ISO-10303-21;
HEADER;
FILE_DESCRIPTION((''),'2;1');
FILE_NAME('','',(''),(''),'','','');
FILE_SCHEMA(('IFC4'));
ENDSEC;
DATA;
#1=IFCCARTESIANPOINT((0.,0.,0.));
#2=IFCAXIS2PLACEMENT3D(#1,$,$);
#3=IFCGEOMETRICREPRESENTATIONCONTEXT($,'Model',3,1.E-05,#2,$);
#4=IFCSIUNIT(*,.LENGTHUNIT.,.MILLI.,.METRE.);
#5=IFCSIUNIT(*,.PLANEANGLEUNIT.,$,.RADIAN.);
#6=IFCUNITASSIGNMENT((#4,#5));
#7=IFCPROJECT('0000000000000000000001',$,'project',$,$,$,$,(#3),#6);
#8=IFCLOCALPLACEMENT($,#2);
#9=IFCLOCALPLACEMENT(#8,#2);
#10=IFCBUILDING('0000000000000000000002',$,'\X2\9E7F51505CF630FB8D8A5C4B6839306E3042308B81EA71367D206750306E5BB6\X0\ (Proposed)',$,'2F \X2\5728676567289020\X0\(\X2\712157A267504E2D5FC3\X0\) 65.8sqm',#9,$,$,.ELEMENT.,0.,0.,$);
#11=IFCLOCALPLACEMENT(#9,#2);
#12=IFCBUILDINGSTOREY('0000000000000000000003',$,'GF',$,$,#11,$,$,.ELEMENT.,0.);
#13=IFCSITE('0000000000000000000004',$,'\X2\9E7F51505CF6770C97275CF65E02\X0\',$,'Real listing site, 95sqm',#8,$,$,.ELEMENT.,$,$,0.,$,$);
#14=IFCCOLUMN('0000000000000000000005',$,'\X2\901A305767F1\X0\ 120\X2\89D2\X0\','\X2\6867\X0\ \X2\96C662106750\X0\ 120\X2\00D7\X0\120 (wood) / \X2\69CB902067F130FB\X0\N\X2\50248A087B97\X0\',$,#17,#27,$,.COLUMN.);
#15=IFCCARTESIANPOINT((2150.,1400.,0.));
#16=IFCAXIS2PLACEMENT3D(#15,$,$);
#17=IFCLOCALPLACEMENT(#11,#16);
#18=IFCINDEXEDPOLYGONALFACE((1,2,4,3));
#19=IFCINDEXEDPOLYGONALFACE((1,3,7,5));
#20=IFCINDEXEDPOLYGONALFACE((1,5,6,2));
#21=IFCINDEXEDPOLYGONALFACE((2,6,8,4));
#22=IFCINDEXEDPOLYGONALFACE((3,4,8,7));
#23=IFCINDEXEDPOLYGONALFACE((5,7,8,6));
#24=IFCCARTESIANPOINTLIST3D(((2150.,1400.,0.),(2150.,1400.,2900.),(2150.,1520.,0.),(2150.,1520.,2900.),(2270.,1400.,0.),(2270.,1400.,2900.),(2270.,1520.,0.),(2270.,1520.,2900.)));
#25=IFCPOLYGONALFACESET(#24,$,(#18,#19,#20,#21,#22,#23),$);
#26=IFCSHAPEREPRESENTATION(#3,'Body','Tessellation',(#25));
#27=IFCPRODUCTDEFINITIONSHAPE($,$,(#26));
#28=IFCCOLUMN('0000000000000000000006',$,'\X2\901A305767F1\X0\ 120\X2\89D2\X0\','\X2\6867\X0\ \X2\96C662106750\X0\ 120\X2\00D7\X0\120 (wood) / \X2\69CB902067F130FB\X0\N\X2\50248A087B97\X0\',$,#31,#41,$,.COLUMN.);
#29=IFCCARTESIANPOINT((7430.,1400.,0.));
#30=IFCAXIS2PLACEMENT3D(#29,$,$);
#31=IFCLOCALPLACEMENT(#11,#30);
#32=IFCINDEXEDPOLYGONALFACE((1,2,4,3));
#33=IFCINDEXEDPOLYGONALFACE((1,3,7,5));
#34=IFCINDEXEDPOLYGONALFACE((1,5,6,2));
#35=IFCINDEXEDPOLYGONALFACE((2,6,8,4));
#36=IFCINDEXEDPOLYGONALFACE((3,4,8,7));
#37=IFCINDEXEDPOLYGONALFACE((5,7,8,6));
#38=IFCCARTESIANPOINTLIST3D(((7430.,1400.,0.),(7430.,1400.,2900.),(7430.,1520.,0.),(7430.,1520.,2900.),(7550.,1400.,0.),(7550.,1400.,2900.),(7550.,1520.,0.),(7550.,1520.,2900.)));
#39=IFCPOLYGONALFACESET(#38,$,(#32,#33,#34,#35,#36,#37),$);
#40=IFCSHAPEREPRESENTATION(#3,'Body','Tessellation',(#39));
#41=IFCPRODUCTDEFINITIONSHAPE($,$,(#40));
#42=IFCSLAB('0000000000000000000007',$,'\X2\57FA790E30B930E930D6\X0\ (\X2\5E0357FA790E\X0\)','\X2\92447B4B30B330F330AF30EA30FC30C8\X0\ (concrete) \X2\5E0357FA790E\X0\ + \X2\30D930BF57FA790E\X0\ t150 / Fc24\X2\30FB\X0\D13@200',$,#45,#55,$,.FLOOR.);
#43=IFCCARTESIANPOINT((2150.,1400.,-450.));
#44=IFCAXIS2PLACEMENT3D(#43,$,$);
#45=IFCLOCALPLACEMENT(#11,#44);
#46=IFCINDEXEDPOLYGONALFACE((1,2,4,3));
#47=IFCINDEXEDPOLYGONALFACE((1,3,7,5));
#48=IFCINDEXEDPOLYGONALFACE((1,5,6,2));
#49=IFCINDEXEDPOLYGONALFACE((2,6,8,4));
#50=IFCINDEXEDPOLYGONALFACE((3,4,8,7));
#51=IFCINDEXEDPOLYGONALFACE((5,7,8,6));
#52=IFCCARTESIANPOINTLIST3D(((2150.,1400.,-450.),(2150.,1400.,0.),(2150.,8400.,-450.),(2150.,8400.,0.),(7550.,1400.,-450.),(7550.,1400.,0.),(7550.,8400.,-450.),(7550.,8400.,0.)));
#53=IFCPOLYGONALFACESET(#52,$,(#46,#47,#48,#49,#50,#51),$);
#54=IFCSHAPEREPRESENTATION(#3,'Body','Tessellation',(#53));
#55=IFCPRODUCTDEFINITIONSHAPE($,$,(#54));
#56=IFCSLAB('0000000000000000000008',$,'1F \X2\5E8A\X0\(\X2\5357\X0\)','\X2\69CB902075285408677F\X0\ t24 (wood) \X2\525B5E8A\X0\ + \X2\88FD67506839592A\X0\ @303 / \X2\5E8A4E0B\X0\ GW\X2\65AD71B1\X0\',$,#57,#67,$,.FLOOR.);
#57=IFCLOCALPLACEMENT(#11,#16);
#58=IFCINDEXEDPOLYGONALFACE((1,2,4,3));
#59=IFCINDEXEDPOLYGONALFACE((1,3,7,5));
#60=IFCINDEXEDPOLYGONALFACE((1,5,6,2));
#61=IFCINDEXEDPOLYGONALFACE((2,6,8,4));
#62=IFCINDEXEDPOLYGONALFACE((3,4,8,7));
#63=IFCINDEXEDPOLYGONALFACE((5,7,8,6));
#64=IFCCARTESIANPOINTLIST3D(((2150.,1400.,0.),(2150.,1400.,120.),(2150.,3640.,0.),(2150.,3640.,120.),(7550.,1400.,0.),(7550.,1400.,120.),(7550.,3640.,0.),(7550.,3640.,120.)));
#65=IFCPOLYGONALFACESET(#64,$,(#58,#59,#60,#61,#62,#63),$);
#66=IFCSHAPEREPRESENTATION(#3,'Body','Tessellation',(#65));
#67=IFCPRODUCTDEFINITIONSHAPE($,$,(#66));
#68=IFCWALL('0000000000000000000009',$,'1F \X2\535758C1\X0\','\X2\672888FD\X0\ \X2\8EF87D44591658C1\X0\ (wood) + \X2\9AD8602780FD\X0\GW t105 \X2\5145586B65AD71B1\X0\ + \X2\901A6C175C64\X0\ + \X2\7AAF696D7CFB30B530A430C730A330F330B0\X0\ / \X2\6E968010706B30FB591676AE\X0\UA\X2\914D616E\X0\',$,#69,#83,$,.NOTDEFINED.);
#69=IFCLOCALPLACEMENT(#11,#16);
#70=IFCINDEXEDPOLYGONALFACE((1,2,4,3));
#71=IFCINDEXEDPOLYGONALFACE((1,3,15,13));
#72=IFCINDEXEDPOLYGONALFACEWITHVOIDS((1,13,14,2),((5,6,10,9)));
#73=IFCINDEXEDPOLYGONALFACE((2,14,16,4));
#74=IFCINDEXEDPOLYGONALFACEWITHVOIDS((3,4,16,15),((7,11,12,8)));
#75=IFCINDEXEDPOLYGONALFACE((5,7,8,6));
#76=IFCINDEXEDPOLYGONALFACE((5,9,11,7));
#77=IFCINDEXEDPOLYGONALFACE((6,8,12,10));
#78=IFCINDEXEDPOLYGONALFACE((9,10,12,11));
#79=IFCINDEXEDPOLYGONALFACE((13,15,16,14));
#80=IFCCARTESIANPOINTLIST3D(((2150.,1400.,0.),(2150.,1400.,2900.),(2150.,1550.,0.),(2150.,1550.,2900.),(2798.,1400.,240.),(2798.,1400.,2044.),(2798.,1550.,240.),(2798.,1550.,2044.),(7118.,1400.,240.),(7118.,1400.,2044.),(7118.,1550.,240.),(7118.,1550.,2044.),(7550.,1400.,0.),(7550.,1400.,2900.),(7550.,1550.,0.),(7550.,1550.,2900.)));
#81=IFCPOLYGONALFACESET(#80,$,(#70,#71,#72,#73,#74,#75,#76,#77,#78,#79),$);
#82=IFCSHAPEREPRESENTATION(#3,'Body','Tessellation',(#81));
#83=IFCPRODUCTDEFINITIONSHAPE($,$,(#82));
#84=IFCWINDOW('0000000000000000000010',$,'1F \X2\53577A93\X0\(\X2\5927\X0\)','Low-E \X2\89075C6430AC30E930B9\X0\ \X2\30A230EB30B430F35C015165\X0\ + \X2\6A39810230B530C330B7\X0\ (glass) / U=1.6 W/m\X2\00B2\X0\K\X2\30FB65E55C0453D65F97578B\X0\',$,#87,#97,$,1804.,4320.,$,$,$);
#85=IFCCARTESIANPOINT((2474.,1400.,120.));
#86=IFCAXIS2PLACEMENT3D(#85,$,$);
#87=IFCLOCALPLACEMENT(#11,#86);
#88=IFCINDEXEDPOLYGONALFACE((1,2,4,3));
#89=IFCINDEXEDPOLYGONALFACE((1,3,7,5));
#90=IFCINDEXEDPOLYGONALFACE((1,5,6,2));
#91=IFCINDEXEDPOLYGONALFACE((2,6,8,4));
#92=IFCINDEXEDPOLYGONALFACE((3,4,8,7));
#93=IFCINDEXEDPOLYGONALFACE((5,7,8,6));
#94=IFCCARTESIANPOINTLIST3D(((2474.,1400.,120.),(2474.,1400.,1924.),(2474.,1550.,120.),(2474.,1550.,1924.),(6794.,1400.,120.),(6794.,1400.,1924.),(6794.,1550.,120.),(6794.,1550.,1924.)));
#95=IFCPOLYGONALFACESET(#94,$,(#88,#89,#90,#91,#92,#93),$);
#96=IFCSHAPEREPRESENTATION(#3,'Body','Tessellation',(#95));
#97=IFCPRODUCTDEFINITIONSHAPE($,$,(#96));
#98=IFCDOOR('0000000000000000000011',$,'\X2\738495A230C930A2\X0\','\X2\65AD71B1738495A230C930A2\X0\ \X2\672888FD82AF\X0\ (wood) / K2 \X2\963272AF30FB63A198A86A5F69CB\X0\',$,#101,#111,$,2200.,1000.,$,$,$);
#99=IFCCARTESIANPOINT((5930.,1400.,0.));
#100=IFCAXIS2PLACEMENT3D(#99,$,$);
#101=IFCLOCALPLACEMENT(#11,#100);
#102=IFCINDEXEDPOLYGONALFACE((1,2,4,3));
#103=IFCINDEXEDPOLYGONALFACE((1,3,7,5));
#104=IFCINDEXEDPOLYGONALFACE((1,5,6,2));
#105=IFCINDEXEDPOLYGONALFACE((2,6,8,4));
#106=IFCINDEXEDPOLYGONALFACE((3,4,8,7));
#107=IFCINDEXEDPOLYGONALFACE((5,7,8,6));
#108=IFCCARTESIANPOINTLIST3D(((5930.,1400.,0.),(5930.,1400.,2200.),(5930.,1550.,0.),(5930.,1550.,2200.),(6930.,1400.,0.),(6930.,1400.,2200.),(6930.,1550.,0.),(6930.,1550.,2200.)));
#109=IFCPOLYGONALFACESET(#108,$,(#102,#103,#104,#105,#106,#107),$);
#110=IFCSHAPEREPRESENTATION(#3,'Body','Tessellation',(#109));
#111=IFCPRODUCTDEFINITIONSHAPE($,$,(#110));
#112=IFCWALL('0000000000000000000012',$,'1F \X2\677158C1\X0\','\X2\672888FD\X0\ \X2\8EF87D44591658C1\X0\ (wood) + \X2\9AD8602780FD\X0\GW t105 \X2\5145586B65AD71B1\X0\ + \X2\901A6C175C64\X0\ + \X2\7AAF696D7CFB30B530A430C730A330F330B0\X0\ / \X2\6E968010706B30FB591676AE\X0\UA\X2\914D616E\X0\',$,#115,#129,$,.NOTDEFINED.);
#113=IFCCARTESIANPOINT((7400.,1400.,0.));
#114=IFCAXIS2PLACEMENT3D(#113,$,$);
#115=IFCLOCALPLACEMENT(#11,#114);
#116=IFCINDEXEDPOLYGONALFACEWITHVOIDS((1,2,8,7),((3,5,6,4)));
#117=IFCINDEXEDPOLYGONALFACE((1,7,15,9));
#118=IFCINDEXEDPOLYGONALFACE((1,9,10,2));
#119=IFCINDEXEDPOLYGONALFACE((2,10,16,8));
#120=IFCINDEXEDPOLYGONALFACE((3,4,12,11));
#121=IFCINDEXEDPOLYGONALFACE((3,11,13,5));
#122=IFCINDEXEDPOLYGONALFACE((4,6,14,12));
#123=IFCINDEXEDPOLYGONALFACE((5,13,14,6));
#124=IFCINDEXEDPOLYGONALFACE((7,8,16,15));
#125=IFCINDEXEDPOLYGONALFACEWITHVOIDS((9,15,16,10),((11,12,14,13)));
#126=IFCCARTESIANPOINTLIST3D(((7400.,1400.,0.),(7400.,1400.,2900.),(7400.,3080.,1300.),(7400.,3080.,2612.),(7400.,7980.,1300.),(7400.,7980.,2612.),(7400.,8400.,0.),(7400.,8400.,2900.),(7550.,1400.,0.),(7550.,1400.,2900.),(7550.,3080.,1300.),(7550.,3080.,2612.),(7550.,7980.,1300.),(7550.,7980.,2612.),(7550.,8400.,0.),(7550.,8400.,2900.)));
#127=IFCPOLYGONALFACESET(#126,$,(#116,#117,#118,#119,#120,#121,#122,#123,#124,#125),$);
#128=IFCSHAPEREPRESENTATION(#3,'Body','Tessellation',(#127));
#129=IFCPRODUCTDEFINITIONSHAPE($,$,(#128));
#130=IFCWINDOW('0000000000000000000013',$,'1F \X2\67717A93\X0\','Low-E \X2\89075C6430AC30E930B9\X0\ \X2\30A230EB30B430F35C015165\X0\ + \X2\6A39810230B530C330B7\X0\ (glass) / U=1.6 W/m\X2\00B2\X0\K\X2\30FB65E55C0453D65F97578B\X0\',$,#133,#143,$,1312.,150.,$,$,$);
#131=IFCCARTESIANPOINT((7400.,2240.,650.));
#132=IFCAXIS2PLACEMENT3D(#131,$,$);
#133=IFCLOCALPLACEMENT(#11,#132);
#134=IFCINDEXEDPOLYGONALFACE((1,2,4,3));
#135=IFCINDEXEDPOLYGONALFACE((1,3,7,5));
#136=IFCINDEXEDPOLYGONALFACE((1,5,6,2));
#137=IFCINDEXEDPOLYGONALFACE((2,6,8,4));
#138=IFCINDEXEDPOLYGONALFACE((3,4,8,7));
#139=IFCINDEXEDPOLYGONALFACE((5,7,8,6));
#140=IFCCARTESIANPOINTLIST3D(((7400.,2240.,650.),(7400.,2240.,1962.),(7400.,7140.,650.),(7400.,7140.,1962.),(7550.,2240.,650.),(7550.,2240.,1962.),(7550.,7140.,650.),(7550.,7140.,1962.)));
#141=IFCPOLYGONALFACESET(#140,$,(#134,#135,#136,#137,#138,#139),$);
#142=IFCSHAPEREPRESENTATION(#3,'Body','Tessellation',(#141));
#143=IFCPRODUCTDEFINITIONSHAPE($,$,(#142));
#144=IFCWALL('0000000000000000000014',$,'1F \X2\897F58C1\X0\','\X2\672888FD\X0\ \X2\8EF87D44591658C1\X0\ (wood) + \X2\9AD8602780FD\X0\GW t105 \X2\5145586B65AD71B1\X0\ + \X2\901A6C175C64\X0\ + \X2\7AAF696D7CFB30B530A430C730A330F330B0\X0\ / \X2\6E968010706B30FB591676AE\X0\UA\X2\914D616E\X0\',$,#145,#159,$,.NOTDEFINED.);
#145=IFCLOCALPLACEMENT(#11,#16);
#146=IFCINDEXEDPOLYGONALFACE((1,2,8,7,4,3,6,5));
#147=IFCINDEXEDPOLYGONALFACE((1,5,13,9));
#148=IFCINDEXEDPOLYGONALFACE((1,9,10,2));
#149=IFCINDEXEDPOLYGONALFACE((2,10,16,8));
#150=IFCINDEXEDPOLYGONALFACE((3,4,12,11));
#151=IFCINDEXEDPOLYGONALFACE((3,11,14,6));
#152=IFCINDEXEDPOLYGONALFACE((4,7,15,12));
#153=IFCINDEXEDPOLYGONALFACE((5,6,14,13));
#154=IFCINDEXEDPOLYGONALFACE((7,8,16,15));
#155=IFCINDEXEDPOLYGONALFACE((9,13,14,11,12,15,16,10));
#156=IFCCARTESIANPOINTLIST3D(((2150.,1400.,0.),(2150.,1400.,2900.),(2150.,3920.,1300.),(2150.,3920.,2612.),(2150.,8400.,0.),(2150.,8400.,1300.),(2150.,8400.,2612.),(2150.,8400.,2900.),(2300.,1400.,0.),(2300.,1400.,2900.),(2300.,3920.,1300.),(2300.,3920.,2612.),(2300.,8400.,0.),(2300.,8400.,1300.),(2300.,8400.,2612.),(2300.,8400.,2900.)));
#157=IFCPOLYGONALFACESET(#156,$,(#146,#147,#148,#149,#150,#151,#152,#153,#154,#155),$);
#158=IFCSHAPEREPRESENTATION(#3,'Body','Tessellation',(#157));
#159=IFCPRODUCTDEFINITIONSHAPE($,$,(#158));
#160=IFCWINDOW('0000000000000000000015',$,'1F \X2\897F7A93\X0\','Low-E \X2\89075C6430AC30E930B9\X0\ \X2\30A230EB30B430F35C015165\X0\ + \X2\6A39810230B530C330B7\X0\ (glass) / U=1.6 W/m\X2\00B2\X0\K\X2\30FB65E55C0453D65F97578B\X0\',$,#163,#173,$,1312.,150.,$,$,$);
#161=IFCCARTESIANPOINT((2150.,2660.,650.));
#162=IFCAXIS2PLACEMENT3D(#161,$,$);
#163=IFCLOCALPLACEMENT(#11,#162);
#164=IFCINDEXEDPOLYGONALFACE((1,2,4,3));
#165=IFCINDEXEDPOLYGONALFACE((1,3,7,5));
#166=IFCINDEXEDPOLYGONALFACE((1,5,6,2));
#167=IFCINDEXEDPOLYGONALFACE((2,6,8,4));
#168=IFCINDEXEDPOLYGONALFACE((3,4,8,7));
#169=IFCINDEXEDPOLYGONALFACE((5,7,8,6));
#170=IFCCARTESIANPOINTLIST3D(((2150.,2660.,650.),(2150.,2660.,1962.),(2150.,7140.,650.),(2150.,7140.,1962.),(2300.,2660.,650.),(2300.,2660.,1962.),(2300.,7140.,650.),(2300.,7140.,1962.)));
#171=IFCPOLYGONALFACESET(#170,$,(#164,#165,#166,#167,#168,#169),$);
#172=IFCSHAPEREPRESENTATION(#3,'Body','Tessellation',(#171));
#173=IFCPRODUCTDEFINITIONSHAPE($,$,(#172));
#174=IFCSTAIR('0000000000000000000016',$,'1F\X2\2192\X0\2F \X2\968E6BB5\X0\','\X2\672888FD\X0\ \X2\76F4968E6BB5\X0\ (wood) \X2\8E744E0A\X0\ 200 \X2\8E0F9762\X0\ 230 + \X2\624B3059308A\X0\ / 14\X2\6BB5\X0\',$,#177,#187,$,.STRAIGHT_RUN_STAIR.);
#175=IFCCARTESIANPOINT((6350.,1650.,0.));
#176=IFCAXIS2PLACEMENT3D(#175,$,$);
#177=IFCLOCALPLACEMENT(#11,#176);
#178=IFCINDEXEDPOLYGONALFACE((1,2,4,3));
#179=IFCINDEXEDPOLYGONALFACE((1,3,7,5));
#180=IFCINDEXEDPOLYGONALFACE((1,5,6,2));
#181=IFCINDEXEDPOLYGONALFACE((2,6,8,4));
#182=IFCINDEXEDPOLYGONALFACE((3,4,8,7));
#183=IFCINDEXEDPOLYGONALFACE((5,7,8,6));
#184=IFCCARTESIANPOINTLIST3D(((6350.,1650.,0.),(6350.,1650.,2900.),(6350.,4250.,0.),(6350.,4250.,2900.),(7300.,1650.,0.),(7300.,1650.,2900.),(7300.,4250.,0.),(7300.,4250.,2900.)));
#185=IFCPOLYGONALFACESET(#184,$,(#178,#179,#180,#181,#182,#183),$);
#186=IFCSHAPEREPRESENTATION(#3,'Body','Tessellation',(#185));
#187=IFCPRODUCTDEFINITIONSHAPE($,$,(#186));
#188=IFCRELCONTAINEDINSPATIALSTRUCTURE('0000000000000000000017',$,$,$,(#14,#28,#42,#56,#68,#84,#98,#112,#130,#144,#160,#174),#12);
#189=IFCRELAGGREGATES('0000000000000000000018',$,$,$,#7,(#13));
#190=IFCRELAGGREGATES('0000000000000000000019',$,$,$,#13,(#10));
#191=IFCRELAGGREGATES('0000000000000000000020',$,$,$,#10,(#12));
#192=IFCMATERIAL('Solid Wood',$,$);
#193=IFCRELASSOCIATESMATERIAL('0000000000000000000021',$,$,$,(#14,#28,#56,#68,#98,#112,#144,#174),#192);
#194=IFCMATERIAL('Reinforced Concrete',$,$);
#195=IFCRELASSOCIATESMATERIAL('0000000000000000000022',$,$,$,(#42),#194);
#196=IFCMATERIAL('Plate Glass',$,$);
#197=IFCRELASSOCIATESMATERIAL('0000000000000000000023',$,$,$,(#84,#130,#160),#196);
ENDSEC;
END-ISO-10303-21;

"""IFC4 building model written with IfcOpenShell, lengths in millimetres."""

from ifc_helpers import new_model, si_unit, frame, frame_2d, origin, place, context, project, spatial, rectangle, extrude, material, element, fill, save


model = new_model("IFC4")

# Units and contexts
model_context = context("Model", 3, precision=1e-05, world=origin())
ifc_project = project(units=[si_unit("LENGTHUNIT", "METRE", prefix="MILLI"), si_unit("PLANEANGLEUNIT", "RADIAN")], contexts=[model_context])

# Site, building, storey
site_placement = place(None, origin())
site = spatial("IfcSite", under=ifc_project, at=site_placement, Name="鹿児島県霧島市", ObjectType="Real listing site, 95sqm", CompositionType="ELEMENT", RefElevation=0.0)
building_placement = place(site_placement, origin())
building = spatial("IfcBuilding", under=site, at=building_placement, Name="鹿児島・越屋根のある自然素材の家 (Proposed)", ObjectType="2F 在来木造(無垢材中心) 65.8sqm", CompositionType="ELEMENT", ElevationOfRefHeight=0.0, ElevationOfTerrain=0.0)
storey_placement = place(building_placement, origin())
storey = spatial("IfcBuildingStorey", under=building, at=storey_placement, Name="GF", CompositionType="ELEMENT", Elevation=0.0)

# Columns
ifc_material_1 = material(Name="Solid Wood")
column_1_placement = place(storey_placement, frame((2150.0, 1400.0, 0.0)))
element("IfcColumn", 1, at=column_1_placement, inside=storey, material=ifc_material_1, Name="通し柱 120角", Description="桧 集成材 120×120 (wood) / 構造柱・N値計算", PredefinedType="COLUMN", context=model_context, shape_type="SweptSolid", body=[
    extrude(rectangle(XDim=120.0, YDim=120.0, at=frame_2d((60.0, 60.0))), frame((2150.0, 1400.0, 0.0)), (0.0, 0.0, 1.0), 2900.0),
])
column_2_placement = place(storey_placement, frame((7430.0, 1400.0, 0.0)))
element("IfcColumn", 2, at=column_2_placement, inside=storey, material=ifc_material_1, Name="通し柱 120角", Description="桧 集成材 120×120 (wood) / 構造柱・N値計算", PredefinedType="COLUMN", context=model_context, shape_type="SweptSolid", body=[
    extrude(rectangle(XDim=120.0, YDim=120.0, at=frame_2d((60.0, 60.0))), frame((7430.0, 1400.0, 0.0)), (0.0, 0.0, 1.0), 2900.0),
])

# Slabs
ifc_material_2 = material(Name="Reinforced Concrete")
slab_1_placement = place(storey_placement, frame((2150.0, 1400.0, -450.0)))
element("IfcSlab", 3, at=slab_1_placement, inside=storey, material=ifc_material_2, Name="基礎スラブ (布基礎)", Description="鉄筋コンクリート (concrete) 布基礎 + ベタ基礎 t150 / Fc24・D13@200", PredefinedType="FLOOR", context=model_context, shape_type="SweptSolid", body=[
    extrude(rectangle(XDim=5400.0, YDim=7000.0, at=frame_2d((2700.0, 3500.0))), frame((2150.0, 1400.0, -450.0)), (0.0, 0.0, 1.0), 450.0),
])
slab_2_placement = place(storey_placement, frame((2150.0, 1400.0, 0.0)))
element("IfcSlab", 4, at=slab_2_placement, inside=storey, material=ifc_material_1, Name="1F 床(南)", Description="構造用合板 t24 (wood) 剛床 + 製材根太 @303 / 床下 GW断熱", PredefinedType="FLOOR", context=model_context, shape_type="SweptSolid", body=[
    extrude(rectangle(XDim=5400.0, YDim=2240.0, at=frame_2d((2700.0, 1120.0))), frame((2150.0, 1400.0, 0.0)), (0.0, 0.0, 1.0), 120.0),
])

# Wall, openings, window, door
wall_1_placement = place(storey_placement, frame((2150.0, 1400.0, 0.0)))
wall_1 = element("IfcWall", 5, at=wall_1_placement, inside=storey, material=ifc_material_1, Name="1F 南壁", Description="木製 軸組外壁 (wood) + 高性能GW t105 充填断熱 + 通気層 + 窯業系サイディング / 準耐火・外皮UA配慮", PredefinedType="NOTDEFINED", context=model_context, shape_type="SweptSolid", body=[
    extrude(rectangle(XDim=5400.0, YDim=150.0, at=frame_2d((2700.0, 75.0))), frame((2150.0, 1400.0, 0.0)), (0.0, 0.0, 1.0), 2900.0),
])
opening_1_placement = place(storey_placement, frame((2474.0, 1400.0, 120.0)))
opening_1 = element("IfcOpeningElement", 6, at=opening_1_placement, cuts=wall_1, PredefinedType="NOTDEFINED", context=model_context, shape_type="SweptSolid", body=[
    extrude(rectangle(XDim=4320.0, YDim=150.0, at=frame_2d((2160.0, 75.0))), frame((2474.0, 1400.0, 120.0)), (0.0, 0.0, 1.0), 1804.0),
])
opening_2_placement = place(storey_placement, frame((5930.0, 1400.0, 0.0)))
opening_2 = element("IfcOpeningElement", 7, at=opening_2_placement, cuts=wall_1, PredefinedType="NOTDEFINED", context=model_context, shape_type="SweptSolid", body=[
    extrude(rectangle(XDim=1000.0, YDim=150.0, at=frame_2d((500.0, 75.0))), frame((5930.0, 1400.0, 0.0)), (0.0, 0.0, 1.0), 2200.0),
])
ifc_material_3 = material(Name="Plate Glass")
window_1_placement = place(storey_placement, frame((2474.0, 1400.0, 120.0)))
window_1 = element("IfcWindow", 8, at=window_1_placement, inside=storey, material=ifc_material_3, Name="1F 南窓(大)", Description="Low-E 複層ガラス アルゴン封入 + 樹脂サッシ (glass) / U=1.6 W/m²K・日射取得型", OverallHeight=1804.0, OverallWidth=4320.0, context=model_context, shape_type="SweptSolid", body=[
    extrude(rectangle(XDim=4320.0, YDim=150.0, at=frame_2d((2160.0, 75.0))), frame((2474.0, 1400.0, 120.0)), (0.0, 0.0, 1.0), 1804.0),
])
fill(opening_1, window_1)
door_placement = place(storey_placement, frame((5930.0, 1400.0, 0.0)))
door = element("IfcDoor", 9, at=door_placement, inside=storey, material=ifc_material_1, Name="玄関ドア", Description="断熱玄関ドア 木製芯 (wood) / K2 防犯・採風機構", OverallHeight=2200.0, OverallWidth=1000.0, context=model_context, shape_type="SweptSolid", body=[
    extrude(rectangle(XDim=1000.0, YDim=150.0, at=frame_2d((500.0, 75.0))), frame((5930.0, 1400.0, 0.0)), (0.0, 0.0, 1.0), 2200.0),
])
fill(opening_2, door)

# Walls, openings, windows
wall_2_placement = place(storey_placement, frame((7400.0, 1400.0, 0.0)))
wall_2 = element("IfcWall", 10, at=wall_2_placement, inside=storey, material=ifc_material_1, Name="1F 東壁", Description="木製 軸組外壁 (wood) + 高性能GW t105 充填断熱 + 通気層 + 窯業系サイディング / 準耐火・外皮UA配慮", PredefinedType="NOTDEFINED", context=model_context, shape_type="SweptSolid", body=[
    extrude(rectangle(XDim=150.0, YDim=7000.0, at=frame_2d((75.0, 3500.0))), frame((7400.0, 1400.0, 0.0)), (0.0, 0.0, 1.0), 2900.0),
])
opening_3_placement = place(storey_placement, frame((7400.0, 2240.0, 650.0)))
opening_3 = element("IfcOpeningElement", 11, at=opening_3_placement, cuts=wall_2, PredefinedType="NOTDEFINED", context=model_context, shape_type="SweptSolid", body=[
    extrude(rectangle(XDim=150.0, YDim=4900.0, at=frame_2d((75.0, 2450.0))), frame((7400.0, 2240.0, 650.0)), (0.0, 0.0, 1.0), 1312.0),
])
window_2_placement = place(storey_placement, frame((7400.0, 2240.0, 650.0)))
window_2 = element("IfcWindow", 12, at=window_2_placement, inside=storey, material=ifc_material_3, Name="1F 東窓", Description="Low-E 複層ガラス アルゴン封入 + 樹脂サッシ (glass) / U=1.6 W/m²K・日射取得型", OverallHeight=1312.0, OverallWidth=150.0, context=model_context, shape_type="SweptSolid", body=[
    extrude(rectangle(XDim=150.0, YDim=4900.0, at=frame_2d((75.0, 2450.0))), frame((7400.0, 2240.0, 650.0)), (0.0, 0.0, 1.0), 1312.0),
])
fill(opening_3, window_2)
wall_3_placement = place(storey_placement, frame((2150.0, 1400.0, 0.0)))
wall_3 = element("IfcWall", 13, at=wall_3_placement, inside=storey, material=ifc_material_1, Name="1F 西壁", Description="木製 軸組外壁 (wood) + 高性能GW t105 充填断熱 + 通気層 + 窯業系サイディング / 準耐火・外皮UA配慮", PredefinedType="NOTDEFINED", context=model_context, shape_type="SweptSolid", body=[
    extrude(rectangle(XDim=150.0, YDim=7000.0, at=frame_2d((75.0, 3500.0))), frame((2150.0, 1400.0, 0.0)), (0.0, 0.0, 1.0), 2900.0),
])
opening_4_placement = place(storey_placement, frame((2150.0, 2660.0, 650.0)))
opening_4 = element("IfcOpeningElement", 14, at=opening_4_placement, cuts=wall_3, PredefinedType="NOTDEFINED", context=model_context, shape_type="SweptSolid", body=[
    extrude(rectangle(XDim=150.0, YDim=4480.0, at=frame_2d((75.0, 2240.0))), frame((2150.0, 2660.0, 650.0)), (0.0, 0.0, 1.0), 1312.0),
])
window_3_placement = place(storey_placement, frame((2150.0, 2660.0, 650.0)))
window_3 = element("IfcWindow", 15, at=window_3_placement, inside=storey, material=ifc_material_3, Name="1F 西窓", Description="Low-E 複層ガラス アルゴン封入 + 樹脂サッシ (glass) / U=1.6 W/m²K・日射取得型", OverallHeight=1312.0, OverallWidth=150.0, context=model_context, shape_type="SweptSolid", body=[
    extrude(rectangle(XDim=150.0, YDim=4480.0, at=frame_2d((75.0, 2240.0))), frame((2150.0, 2660.0, 650.0)), (0.0, 0.0, 1.0), 1312.0),
])
fill(opening_4, window_3)

# Stair
stair_placement = place(storey_placement, frame((6350.0, 1650.0, 0.0)))
element("IfcStair", 16, at=stair_placement, inside=storey, material=ifc_material_1, Name="1F→2F 階段", Description="木製 直階段 (wood) 蹴上 200 踏面 230 + 手すり / 14段", PredefinedType="STRAIGHT_RUN_STAIR", context=model_context, shape_type="SweptSolid", body=[
    extrude(rectangle(XDim=950.0, YDim=2600.0, at=frame_2d((475.0, 1300.0))), frame((6350.0, 1650.0, 0.0)), (0.0, 0.0, 1.0), 2900.0),
])

save(model, "model.ifc")
